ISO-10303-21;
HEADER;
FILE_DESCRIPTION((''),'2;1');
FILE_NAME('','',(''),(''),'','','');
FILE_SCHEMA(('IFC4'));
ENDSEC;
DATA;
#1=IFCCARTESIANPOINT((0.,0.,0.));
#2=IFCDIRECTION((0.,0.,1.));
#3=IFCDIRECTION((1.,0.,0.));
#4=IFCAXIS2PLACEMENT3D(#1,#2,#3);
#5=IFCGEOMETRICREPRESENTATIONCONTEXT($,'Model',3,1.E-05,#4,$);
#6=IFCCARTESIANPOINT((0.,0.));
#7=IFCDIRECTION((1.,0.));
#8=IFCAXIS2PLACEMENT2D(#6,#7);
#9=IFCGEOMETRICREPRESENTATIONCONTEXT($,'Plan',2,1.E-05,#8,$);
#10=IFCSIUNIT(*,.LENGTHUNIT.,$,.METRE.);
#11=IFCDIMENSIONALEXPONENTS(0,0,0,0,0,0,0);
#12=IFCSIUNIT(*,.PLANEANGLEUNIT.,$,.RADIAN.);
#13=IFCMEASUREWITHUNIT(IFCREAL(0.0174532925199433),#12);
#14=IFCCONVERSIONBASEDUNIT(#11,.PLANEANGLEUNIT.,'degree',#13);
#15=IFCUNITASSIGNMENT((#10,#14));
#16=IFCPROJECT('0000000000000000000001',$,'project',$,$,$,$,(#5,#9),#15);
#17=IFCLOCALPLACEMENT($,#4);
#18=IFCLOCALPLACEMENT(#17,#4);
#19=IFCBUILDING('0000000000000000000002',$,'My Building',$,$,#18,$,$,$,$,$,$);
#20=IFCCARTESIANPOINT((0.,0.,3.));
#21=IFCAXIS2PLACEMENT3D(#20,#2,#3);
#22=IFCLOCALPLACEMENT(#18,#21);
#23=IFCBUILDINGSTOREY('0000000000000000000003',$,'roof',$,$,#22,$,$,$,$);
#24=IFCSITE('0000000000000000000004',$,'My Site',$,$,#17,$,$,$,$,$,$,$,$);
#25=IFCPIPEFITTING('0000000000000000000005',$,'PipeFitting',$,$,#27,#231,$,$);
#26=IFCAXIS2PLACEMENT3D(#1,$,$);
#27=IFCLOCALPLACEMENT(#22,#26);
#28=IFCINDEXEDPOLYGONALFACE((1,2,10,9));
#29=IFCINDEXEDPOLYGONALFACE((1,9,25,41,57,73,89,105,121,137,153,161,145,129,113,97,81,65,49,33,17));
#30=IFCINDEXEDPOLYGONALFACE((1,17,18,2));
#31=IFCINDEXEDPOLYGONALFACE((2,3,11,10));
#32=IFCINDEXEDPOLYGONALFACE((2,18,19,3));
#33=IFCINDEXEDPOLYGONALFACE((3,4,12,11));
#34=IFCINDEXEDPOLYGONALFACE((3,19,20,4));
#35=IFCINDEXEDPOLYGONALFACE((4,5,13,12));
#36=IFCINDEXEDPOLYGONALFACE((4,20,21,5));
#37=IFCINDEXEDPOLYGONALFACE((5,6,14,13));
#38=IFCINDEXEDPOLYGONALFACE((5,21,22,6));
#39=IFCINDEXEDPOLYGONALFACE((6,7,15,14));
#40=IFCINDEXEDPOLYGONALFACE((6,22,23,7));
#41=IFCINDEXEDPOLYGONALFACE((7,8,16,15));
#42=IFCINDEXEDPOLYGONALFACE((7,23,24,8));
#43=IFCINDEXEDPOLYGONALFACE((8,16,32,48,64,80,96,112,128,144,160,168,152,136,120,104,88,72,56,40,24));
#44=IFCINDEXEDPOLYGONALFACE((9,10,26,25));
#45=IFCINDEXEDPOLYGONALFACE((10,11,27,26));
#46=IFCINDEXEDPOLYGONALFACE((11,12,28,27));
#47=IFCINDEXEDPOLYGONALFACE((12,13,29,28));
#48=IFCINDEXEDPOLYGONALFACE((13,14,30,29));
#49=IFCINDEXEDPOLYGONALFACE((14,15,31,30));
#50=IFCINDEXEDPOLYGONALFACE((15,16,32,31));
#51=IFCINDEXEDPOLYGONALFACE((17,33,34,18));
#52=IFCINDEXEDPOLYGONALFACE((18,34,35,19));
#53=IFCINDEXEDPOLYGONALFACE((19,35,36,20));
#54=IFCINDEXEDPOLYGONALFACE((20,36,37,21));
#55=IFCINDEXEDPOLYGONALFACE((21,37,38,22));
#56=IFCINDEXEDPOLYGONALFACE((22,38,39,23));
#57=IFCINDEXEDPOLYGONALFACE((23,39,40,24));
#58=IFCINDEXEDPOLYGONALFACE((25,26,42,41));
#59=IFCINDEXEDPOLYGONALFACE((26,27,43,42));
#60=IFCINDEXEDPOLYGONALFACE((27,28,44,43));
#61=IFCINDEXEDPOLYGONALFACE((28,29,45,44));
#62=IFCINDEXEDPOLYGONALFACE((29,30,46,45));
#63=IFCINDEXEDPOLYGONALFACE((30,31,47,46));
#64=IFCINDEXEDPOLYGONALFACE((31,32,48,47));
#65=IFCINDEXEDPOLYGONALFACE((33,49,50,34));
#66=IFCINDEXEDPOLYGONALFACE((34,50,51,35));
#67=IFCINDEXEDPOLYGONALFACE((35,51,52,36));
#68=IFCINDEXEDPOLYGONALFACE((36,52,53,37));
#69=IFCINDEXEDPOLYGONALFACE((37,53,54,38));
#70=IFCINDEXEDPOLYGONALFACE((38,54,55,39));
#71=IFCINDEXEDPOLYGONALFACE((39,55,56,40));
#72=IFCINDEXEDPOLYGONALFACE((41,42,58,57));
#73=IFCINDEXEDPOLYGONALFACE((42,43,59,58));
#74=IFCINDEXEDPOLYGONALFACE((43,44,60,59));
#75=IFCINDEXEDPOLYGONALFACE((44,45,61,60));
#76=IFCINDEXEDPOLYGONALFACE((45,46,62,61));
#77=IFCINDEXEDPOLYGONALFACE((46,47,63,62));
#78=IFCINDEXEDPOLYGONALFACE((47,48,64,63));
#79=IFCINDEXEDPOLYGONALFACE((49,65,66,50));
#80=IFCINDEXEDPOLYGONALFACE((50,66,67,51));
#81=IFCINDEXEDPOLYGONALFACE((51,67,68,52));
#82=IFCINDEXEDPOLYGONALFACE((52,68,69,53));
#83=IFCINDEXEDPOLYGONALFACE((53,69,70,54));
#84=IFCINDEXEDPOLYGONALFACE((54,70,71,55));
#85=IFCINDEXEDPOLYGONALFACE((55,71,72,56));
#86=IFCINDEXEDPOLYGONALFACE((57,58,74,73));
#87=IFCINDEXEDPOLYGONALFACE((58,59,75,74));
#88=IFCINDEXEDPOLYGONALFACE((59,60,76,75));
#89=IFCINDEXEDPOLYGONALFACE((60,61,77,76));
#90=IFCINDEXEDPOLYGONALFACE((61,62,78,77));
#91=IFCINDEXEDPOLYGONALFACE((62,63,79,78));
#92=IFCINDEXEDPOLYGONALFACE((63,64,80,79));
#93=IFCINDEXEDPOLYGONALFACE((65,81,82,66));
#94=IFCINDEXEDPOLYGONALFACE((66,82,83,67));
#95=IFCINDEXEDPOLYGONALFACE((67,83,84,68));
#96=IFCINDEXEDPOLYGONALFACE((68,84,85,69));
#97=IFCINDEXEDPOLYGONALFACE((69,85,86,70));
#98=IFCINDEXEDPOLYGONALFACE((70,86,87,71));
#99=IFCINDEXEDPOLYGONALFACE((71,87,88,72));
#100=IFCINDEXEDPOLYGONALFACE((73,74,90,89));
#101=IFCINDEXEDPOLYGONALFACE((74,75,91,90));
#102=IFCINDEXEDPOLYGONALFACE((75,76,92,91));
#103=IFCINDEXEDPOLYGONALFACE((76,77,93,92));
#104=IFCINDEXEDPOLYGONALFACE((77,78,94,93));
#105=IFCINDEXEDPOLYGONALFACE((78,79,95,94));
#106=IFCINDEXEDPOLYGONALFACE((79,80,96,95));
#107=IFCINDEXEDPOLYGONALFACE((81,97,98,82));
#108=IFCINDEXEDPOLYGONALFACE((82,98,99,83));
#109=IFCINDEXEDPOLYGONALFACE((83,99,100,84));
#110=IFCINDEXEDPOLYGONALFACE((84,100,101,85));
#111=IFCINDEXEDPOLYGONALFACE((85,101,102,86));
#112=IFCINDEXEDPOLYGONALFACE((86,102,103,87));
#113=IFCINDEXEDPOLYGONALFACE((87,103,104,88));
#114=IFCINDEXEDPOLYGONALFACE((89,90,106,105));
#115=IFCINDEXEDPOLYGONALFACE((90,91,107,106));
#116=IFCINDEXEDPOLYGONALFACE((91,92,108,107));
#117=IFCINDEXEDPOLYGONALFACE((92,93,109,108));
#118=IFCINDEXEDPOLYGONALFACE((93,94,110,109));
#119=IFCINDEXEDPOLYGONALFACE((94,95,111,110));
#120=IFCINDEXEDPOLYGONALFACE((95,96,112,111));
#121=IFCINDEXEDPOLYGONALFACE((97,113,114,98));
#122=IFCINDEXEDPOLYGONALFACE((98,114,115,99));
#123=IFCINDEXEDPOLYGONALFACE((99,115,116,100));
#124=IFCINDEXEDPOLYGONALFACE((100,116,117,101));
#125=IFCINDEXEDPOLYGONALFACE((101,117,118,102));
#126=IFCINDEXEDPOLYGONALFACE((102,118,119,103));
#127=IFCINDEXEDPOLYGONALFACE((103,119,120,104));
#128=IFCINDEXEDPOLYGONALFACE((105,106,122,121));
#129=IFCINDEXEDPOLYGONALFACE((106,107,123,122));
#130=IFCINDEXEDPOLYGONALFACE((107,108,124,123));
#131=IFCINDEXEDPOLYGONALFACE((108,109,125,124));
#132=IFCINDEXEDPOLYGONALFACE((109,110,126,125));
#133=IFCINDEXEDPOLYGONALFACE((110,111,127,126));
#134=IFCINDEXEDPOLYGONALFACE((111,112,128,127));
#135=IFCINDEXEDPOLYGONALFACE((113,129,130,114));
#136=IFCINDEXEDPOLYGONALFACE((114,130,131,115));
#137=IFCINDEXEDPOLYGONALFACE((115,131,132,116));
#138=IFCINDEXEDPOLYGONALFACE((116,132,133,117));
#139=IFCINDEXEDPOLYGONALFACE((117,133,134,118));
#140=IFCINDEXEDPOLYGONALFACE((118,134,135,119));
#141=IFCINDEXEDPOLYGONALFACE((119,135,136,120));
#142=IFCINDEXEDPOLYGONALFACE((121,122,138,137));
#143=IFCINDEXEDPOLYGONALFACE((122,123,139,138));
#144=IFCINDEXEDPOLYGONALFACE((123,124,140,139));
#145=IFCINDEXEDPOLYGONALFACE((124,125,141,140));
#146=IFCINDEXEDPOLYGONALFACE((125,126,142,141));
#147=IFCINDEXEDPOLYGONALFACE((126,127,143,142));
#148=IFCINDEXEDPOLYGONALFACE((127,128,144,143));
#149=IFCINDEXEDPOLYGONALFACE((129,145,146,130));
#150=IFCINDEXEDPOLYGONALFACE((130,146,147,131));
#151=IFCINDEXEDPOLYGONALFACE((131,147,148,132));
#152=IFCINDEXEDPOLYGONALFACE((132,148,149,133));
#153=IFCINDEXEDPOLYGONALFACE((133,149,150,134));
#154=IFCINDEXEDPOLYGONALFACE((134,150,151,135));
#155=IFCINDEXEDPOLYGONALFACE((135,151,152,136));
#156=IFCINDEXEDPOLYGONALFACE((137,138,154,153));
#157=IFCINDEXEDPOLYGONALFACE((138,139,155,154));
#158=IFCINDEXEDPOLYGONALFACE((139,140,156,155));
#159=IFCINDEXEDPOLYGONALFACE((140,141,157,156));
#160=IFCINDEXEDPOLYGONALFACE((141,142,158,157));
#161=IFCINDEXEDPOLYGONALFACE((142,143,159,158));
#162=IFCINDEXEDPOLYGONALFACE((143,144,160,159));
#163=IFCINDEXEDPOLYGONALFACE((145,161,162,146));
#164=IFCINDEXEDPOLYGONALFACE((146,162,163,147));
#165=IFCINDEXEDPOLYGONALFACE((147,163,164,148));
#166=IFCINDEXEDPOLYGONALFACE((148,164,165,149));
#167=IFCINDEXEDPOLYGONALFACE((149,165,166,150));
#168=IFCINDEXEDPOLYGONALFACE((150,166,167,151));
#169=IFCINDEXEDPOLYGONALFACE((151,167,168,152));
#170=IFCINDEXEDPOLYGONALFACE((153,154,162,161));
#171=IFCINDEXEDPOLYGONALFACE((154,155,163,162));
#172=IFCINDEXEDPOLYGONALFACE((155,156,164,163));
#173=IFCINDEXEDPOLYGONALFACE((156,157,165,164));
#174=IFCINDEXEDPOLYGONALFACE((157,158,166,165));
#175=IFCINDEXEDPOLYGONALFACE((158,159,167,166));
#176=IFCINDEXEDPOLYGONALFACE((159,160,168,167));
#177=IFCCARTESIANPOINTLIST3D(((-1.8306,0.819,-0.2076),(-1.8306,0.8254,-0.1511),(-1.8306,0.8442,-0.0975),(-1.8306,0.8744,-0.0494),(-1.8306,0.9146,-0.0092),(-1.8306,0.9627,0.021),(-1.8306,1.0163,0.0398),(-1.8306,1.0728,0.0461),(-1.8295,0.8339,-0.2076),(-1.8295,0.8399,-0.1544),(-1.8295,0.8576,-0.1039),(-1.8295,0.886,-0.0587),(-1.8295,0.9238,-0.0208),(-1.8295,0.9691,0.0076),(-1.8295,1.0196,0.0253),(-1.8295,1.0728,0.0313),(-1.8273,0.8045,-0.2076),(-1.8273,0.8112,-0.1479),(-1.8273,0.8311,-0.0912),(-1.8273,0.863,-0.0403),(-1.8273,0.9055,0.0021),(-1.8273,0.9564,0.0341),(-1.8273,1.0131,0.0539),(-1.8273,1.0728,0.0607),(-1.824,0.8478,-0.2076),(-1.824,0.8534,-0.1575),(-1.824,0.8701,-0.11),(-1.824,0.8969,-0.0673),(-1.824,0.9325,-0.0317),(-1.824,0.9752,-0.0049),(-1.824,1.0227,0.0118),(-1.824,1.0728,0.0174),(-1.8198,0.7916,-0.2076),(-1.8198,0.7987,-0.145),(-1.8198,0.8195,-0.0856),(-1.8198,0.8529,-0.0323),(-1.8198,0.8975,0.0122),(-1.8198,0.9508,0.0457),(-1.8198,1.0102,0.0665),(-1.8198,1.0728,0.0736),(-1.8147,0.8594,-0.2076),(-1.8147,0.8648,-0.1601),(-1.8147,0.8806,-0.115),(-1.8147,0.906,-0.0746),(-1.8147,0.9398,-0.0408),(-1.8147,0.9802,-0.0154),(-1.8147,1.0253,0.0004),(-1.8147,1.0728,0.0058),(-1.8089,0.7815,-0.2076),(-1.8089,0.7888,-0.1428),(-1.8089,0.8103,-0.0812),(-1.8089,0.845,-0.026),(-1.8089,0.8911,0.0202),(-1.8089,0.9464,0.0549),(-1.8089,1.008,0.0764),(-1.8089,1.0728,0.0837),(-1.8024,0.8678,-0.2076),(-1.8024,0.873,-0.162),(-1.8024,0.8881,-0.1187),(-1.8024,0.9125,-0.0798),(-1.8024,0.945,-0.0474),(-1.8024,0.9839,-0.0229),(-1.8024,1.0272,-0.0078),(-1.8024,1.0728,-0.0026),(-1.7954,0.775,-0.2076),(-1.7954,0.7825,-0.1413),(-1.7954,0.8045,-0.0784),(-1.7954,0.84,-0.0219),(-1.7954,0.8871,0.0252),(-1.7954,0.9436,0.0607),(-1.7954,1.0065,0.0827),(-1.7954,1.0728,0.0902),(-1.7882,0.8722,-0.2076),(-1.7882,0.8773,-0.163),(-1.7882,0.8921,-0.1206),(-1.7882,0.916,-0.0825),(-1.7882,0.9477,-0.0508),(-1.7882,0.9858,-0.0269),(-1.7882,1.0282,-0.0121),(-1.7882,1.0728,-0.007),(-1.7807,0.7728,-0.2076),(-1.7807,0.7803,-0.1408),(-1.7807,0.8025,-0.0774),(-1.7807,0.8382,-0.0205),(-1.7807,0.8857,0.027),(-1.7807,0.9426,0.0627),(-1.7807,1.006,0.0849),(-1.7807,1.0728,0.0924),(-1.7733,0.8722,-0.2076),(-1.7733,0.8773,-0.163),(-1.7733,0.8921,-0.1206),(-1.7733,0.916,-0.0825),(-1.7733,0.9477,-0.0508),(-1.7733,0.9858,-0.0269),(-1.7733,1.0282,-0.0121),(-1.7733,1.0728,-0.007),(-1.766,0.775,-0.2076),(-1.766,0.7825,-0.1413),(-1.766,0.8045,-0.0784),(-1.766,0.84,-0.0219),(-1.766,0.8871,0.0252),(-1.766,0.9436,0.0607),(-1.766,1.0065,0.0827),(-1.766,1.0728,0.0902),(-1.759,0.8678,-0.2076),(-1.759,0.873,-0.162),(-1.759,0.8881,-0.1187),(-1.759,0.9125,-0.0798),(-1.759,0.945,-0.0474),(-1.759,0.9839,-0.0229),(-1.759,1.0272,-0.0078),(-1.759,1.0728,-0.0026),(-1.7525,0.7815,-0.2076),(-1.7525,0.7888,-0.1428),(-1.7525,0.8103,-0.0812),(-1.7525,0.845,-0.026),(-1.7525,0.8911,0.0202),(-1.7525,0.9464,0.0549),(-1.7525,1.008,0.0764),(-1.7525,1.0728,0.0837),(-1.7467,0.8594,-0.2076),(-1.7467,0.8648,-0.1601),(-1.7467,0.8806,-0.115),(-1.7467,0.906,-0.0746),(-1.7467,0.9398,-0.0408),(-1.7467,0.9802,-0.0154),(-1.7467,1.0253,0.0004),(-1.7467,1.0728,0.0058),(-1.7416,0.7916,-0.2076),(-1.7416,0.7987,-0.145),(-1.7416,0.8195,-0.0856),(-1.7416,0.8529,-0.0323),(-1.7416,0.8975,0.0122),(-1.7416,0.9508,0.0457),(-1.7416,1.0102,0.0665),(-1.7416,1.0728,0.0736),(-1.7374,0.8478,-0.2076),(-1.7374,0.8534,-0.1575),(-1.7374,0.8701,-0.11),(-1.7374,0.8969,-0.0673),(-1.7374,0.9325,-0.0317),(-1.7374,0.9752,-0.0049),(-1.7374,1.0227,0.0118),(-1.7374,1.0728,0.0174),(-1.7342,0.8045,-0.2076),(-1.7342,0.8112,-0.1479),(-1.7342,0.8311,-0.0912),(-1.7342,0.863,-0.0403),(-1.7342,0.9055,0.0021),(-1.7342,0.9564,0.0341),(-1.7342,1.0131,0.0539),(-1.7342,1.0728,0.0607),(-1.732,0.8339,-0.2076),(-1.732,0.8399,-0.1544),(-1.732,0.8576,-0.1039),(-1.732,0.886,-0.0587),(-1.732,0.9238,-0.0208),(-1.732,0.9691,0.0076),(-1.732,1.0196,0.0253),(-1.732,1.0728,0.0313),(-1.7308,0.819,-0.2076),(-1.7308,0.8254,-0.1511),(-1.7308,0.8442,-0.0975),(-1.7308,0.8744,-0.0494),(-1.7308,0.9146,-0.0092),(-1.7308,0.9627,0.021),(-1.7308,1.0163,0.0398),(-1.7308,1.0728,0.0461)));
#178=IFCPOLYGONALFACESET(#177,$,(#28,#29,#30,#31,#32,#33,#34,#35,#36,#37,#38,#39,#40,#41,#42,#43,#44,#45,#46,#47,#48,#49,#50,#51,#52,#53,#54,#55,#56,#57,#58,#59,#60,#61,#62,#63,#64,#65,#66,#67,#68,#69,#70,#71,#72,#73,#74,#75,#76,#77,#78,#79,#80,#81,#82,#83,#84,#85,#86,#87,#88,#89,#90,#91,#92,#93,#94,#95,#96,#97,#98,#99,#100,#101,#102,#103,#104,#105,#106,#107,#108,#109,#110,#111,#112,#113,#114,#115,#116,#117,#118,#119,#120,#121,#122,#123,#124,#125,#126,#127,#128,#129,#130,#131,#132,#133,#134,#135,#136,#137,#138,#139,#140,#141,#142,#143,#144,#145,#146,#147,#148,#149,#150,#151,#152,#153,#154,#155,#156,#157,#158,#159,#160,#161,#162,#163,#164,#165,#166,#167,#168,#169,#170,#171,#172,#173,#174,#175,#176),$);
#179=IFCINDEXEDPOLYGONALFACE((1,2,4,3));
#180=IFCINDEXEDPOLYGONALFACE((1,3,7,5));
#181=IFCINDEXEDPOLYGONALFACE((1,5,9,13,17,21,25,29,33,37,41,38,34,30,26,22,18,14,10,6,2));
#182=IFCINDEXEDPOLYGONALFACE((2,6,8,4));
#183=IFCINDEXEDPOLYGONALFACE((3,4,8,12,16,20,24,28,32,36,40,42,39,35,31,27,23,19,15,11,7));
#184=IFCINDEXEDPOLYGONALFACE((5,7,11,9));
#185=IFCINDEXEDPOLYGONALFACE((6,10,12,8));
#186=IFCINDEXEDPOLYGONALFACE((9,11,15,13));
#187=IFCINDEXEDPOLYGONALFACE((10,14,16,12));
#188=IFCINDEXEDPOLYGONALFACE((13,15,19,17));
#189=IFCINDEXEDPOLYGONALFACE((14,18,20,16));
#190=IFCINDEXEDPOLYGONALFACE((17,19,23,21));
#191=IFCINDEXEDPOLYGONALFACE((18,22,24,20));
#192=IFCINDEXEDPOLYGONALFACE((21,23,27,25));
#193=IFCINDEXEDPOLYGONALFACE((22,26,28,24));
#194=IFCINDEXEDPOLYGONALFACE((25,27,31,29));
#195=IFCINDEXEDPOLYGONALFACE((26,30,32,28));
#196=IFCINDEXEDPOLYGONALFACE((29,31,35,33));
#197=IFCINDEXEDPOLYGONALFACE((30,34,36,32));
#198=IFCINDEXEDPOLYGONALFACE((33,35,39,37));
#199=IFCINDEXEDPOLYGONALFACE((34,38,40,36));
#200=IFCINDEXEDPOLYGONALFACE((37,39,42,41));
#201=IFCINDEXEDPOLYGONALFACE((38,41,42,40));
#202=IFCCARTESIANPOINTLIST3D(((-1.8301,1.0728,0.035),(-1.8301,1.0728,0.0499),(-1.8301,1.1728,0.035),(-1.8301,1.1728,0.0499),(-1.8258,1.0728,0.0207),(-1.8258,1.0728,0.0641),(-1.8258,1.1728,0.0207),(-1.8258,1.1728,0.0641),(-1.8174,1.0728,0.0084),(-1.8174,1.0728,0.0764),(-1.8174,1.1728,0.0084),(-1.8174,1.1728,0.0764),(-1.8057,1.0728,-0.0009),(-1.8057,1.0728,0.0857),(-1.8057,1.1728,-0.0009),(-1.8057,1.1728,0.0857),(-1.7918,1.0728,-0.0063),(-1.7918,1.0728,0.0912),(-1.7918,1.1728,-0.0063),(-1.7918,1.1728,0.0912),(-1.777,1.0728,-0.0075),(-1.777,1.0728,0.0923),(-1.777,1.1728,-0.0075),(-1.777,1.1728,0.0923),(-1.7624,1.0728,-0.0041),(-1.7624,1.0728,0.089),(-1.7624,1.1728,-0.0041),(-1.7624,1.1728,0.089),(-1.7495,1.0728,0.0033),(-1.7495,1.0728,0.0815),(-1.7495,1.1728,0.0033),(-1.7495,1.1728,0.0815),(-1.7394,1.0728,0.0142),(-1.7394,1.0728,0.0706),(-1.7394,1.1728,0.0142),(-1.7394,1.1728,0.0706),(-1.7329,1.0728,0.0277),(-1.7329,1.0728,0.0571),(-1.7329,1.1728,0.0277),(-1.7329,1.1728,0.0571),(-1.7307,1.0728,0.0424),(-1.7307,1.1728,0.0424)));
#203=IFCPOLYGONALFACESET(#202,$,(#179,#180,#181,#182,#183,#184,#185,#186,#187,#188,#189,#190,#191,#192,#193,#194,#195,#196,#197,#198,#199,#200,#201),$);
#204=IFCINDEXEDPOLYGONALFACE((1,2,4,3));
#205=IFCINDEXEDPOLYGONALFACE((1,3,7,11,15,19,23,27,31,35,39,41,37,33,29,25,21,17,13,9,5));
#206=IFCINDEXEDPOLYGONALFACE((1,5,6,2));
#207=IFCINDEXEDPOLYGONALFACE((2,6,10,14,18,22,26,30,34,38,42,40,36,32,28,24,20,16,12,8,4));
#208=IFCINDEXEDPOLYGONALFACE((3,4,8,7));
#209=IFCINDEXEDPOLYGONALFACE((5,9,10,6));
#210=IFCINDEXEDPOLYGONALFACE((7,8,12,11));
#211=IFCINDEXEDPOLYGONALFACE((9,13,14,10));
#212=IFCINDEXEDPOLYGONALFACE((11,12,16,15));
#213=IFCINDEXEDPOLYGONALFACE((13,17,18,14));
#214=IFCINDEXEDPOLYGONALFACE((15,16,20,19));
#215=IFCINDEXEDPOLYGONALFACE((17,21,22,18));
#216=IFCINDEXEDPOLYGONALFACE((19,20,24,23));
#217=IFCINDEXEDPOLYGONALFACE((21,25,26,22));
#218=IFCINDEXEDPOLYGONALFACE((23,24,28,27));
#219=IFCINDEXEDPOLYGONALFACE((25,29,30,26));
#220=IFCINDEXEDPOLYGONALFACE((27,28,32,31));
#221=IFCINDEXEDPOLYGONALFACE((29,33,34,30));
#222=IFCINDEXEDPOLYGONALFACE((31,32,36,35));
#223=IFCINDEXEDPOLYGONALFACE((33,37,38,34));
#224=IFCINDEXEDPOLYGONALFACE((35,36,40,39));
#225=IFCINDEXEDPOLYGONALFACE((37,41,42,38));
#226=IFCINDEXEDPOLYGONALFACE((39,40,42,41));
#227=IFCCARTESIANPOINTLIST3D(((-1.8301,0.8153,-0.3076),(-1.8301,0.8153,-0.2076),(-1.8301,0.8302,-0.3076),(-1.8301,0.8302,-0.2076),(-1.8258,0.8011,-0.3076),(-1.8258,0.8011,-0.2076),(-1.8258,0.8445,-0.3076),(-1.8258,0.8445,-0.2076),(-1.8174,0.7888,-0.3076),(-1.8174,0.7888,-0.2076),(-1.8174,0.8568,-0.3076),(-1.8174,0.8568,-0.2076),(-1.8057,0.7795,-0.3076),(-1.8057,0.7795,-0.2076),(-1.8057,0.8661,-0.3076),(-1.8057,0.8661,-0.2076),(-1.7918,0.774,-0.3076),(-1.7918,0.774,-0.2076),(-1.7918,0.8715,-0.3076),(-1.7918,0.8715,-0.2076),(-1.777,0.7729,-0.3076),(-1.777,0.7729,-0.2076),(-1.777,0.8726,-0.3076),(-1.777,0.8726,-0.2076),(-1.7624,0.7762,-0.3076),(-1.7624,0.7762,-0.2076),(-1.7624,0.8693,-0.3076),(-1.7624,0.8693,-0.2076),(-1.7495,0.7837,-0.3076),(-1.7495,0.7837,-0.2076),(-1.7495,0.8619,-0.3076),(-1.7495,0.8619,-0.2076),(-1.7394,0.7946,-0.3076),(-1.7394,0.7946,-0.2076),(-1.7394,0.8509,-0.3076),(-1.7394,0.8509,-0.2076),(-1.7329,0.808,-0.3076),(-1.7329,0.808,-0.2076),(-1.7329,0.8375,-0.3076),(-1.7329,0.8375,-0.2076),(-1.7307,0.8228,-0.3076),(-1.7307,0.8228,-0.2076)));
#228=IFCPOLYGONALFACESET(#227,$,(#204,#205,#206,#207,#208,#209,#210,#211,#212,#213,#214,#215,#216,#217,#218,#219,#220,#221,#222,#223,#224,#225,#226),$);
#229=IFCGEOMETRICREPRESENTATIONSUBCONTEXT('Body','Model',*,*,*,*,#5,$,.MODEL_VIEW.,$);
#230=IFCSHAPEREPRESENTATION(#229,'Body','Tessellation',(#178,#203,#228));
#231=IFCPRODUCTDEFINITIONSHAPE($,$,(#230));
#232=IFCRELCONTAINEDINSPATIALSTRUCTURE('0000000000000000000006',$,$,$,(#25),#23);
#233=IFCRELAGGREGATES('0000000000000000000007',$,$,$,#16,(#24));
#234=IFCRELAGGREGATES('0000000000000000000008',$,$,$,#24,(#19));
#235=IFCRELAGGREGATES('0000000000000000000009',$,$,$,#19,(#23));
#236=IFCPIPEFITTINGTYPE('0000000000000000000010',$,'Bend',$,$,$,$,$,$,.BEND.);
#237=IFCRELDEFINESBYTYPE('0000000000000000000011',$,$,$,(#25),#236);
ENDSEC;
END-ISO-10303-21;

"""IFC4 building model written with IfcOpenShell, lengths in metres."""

from ifc_helpers import new_model, entity, si_unit, converted_unit, frame, origin_with_axes, origin_2d_with_axis, place, context, subcontext, project, spatial, circle, extrude, source, transform, mapped, type_object, type_shapes, element, save


model = new_model("IFC4")

# Units and contexts
model_context = context("Model", 3, precision=1e-05, world=origin_with_axes())
plan_context = context("Plan", 2, precision=1e-05, world=origin_2d_with_axis())
body_context = subcontext(model_context, "Body", "Model", "MODEL_VIEW")
ifc_project = project(units=[si_unit("LENGTHUNIT", "METRE"), converted_unit("PLANEANGLEUNIT", "degree", entity("IfcReal", 0.0174532925199433), si_unit("PLANEANGLEUNIT", "RADIAN"), dimensions=[0, 0, 0, 0, 0, 0, 0])], contexts=[model_context, plan_context])

# Site, building, storey
site_placement = place(None, origin_with_axes())
site = spatial("IfcSite", under=ifc_project, at=site_placement, Name="My Site")
building_placement = place(site_placement, origin_with_axes())
building = spatial("IfcBuilding", under=site, at=building_placement, Name="My Building")
storey_placement = place(building_placement, frame((0.0, 0.0, 3.0), z_axis=(0.0, 0.0, 1.0), x_axis=(1.0, 0.0, 0.0)))
storey = spatial("IfcBuildingStorey", under=building, at=storey_placement, Name="roof")

# Pipe fitting
pipe_fitting_type_1 = type_object("IfcPipeFittingType", Name="Bend", PredefinedType="BEND")
shared_shape_1 = source(origin_with_axes(), body_context, "Body", "SolidModel", [
    entity("IfcSweptDiskSolid", entity("IfcIndexedPolyCurve", entity("IfcCartesianPointList3D", [[0.0, 0.0, 0.1], [0.0, -0.0732, 0.2768], [0.0, -0.25, 0.35]]), [entity("IfcArcIndex", [1, 2, 3])]), 0.05),
    extrude(circle(Radius=0.05), origin_with_axes(), (0.0, 0.0, 1.0), 0.1),
    extrude(circle(Radius=0.05), frame((0.0, -0.25, 0.35), z_axis=(0.0, -1.0, 0.000008), x_axis=(1.0, 0.0, 0.0)), (0.0, 0.0, 1.0), 0.1),
])
type_shapes(pipe_fitting_type_1, [shared_shape_1])
for number, where, z_axis, x_axis, name in (
    (1, (-1.7807, 1.1728, 0.0424), (0.0, -1.0, -0.000008), (1.0, 0.0, 0.0), "PipeFitting"),
):
    element("IfcPipeFitting", number, at=place(storey_placement, frame(where, z_axis=z_axis, x_axis=x_axis)), inside=storey, type_object=pipe_fitting_type_1, Name=name, context=body_context, shape_type="MappedRepresentation", body=[
        mapped(shared_shape_1, transform((0.0, 0.0, 0.0), x_axis=(1.0, 0.0, 0.0), y_axis=(0.0, 1.0, 0.0), z_axis=(0.0, 0.0, 1.0), scale=1.0)),
    ])

save(model, "model.ifc")
